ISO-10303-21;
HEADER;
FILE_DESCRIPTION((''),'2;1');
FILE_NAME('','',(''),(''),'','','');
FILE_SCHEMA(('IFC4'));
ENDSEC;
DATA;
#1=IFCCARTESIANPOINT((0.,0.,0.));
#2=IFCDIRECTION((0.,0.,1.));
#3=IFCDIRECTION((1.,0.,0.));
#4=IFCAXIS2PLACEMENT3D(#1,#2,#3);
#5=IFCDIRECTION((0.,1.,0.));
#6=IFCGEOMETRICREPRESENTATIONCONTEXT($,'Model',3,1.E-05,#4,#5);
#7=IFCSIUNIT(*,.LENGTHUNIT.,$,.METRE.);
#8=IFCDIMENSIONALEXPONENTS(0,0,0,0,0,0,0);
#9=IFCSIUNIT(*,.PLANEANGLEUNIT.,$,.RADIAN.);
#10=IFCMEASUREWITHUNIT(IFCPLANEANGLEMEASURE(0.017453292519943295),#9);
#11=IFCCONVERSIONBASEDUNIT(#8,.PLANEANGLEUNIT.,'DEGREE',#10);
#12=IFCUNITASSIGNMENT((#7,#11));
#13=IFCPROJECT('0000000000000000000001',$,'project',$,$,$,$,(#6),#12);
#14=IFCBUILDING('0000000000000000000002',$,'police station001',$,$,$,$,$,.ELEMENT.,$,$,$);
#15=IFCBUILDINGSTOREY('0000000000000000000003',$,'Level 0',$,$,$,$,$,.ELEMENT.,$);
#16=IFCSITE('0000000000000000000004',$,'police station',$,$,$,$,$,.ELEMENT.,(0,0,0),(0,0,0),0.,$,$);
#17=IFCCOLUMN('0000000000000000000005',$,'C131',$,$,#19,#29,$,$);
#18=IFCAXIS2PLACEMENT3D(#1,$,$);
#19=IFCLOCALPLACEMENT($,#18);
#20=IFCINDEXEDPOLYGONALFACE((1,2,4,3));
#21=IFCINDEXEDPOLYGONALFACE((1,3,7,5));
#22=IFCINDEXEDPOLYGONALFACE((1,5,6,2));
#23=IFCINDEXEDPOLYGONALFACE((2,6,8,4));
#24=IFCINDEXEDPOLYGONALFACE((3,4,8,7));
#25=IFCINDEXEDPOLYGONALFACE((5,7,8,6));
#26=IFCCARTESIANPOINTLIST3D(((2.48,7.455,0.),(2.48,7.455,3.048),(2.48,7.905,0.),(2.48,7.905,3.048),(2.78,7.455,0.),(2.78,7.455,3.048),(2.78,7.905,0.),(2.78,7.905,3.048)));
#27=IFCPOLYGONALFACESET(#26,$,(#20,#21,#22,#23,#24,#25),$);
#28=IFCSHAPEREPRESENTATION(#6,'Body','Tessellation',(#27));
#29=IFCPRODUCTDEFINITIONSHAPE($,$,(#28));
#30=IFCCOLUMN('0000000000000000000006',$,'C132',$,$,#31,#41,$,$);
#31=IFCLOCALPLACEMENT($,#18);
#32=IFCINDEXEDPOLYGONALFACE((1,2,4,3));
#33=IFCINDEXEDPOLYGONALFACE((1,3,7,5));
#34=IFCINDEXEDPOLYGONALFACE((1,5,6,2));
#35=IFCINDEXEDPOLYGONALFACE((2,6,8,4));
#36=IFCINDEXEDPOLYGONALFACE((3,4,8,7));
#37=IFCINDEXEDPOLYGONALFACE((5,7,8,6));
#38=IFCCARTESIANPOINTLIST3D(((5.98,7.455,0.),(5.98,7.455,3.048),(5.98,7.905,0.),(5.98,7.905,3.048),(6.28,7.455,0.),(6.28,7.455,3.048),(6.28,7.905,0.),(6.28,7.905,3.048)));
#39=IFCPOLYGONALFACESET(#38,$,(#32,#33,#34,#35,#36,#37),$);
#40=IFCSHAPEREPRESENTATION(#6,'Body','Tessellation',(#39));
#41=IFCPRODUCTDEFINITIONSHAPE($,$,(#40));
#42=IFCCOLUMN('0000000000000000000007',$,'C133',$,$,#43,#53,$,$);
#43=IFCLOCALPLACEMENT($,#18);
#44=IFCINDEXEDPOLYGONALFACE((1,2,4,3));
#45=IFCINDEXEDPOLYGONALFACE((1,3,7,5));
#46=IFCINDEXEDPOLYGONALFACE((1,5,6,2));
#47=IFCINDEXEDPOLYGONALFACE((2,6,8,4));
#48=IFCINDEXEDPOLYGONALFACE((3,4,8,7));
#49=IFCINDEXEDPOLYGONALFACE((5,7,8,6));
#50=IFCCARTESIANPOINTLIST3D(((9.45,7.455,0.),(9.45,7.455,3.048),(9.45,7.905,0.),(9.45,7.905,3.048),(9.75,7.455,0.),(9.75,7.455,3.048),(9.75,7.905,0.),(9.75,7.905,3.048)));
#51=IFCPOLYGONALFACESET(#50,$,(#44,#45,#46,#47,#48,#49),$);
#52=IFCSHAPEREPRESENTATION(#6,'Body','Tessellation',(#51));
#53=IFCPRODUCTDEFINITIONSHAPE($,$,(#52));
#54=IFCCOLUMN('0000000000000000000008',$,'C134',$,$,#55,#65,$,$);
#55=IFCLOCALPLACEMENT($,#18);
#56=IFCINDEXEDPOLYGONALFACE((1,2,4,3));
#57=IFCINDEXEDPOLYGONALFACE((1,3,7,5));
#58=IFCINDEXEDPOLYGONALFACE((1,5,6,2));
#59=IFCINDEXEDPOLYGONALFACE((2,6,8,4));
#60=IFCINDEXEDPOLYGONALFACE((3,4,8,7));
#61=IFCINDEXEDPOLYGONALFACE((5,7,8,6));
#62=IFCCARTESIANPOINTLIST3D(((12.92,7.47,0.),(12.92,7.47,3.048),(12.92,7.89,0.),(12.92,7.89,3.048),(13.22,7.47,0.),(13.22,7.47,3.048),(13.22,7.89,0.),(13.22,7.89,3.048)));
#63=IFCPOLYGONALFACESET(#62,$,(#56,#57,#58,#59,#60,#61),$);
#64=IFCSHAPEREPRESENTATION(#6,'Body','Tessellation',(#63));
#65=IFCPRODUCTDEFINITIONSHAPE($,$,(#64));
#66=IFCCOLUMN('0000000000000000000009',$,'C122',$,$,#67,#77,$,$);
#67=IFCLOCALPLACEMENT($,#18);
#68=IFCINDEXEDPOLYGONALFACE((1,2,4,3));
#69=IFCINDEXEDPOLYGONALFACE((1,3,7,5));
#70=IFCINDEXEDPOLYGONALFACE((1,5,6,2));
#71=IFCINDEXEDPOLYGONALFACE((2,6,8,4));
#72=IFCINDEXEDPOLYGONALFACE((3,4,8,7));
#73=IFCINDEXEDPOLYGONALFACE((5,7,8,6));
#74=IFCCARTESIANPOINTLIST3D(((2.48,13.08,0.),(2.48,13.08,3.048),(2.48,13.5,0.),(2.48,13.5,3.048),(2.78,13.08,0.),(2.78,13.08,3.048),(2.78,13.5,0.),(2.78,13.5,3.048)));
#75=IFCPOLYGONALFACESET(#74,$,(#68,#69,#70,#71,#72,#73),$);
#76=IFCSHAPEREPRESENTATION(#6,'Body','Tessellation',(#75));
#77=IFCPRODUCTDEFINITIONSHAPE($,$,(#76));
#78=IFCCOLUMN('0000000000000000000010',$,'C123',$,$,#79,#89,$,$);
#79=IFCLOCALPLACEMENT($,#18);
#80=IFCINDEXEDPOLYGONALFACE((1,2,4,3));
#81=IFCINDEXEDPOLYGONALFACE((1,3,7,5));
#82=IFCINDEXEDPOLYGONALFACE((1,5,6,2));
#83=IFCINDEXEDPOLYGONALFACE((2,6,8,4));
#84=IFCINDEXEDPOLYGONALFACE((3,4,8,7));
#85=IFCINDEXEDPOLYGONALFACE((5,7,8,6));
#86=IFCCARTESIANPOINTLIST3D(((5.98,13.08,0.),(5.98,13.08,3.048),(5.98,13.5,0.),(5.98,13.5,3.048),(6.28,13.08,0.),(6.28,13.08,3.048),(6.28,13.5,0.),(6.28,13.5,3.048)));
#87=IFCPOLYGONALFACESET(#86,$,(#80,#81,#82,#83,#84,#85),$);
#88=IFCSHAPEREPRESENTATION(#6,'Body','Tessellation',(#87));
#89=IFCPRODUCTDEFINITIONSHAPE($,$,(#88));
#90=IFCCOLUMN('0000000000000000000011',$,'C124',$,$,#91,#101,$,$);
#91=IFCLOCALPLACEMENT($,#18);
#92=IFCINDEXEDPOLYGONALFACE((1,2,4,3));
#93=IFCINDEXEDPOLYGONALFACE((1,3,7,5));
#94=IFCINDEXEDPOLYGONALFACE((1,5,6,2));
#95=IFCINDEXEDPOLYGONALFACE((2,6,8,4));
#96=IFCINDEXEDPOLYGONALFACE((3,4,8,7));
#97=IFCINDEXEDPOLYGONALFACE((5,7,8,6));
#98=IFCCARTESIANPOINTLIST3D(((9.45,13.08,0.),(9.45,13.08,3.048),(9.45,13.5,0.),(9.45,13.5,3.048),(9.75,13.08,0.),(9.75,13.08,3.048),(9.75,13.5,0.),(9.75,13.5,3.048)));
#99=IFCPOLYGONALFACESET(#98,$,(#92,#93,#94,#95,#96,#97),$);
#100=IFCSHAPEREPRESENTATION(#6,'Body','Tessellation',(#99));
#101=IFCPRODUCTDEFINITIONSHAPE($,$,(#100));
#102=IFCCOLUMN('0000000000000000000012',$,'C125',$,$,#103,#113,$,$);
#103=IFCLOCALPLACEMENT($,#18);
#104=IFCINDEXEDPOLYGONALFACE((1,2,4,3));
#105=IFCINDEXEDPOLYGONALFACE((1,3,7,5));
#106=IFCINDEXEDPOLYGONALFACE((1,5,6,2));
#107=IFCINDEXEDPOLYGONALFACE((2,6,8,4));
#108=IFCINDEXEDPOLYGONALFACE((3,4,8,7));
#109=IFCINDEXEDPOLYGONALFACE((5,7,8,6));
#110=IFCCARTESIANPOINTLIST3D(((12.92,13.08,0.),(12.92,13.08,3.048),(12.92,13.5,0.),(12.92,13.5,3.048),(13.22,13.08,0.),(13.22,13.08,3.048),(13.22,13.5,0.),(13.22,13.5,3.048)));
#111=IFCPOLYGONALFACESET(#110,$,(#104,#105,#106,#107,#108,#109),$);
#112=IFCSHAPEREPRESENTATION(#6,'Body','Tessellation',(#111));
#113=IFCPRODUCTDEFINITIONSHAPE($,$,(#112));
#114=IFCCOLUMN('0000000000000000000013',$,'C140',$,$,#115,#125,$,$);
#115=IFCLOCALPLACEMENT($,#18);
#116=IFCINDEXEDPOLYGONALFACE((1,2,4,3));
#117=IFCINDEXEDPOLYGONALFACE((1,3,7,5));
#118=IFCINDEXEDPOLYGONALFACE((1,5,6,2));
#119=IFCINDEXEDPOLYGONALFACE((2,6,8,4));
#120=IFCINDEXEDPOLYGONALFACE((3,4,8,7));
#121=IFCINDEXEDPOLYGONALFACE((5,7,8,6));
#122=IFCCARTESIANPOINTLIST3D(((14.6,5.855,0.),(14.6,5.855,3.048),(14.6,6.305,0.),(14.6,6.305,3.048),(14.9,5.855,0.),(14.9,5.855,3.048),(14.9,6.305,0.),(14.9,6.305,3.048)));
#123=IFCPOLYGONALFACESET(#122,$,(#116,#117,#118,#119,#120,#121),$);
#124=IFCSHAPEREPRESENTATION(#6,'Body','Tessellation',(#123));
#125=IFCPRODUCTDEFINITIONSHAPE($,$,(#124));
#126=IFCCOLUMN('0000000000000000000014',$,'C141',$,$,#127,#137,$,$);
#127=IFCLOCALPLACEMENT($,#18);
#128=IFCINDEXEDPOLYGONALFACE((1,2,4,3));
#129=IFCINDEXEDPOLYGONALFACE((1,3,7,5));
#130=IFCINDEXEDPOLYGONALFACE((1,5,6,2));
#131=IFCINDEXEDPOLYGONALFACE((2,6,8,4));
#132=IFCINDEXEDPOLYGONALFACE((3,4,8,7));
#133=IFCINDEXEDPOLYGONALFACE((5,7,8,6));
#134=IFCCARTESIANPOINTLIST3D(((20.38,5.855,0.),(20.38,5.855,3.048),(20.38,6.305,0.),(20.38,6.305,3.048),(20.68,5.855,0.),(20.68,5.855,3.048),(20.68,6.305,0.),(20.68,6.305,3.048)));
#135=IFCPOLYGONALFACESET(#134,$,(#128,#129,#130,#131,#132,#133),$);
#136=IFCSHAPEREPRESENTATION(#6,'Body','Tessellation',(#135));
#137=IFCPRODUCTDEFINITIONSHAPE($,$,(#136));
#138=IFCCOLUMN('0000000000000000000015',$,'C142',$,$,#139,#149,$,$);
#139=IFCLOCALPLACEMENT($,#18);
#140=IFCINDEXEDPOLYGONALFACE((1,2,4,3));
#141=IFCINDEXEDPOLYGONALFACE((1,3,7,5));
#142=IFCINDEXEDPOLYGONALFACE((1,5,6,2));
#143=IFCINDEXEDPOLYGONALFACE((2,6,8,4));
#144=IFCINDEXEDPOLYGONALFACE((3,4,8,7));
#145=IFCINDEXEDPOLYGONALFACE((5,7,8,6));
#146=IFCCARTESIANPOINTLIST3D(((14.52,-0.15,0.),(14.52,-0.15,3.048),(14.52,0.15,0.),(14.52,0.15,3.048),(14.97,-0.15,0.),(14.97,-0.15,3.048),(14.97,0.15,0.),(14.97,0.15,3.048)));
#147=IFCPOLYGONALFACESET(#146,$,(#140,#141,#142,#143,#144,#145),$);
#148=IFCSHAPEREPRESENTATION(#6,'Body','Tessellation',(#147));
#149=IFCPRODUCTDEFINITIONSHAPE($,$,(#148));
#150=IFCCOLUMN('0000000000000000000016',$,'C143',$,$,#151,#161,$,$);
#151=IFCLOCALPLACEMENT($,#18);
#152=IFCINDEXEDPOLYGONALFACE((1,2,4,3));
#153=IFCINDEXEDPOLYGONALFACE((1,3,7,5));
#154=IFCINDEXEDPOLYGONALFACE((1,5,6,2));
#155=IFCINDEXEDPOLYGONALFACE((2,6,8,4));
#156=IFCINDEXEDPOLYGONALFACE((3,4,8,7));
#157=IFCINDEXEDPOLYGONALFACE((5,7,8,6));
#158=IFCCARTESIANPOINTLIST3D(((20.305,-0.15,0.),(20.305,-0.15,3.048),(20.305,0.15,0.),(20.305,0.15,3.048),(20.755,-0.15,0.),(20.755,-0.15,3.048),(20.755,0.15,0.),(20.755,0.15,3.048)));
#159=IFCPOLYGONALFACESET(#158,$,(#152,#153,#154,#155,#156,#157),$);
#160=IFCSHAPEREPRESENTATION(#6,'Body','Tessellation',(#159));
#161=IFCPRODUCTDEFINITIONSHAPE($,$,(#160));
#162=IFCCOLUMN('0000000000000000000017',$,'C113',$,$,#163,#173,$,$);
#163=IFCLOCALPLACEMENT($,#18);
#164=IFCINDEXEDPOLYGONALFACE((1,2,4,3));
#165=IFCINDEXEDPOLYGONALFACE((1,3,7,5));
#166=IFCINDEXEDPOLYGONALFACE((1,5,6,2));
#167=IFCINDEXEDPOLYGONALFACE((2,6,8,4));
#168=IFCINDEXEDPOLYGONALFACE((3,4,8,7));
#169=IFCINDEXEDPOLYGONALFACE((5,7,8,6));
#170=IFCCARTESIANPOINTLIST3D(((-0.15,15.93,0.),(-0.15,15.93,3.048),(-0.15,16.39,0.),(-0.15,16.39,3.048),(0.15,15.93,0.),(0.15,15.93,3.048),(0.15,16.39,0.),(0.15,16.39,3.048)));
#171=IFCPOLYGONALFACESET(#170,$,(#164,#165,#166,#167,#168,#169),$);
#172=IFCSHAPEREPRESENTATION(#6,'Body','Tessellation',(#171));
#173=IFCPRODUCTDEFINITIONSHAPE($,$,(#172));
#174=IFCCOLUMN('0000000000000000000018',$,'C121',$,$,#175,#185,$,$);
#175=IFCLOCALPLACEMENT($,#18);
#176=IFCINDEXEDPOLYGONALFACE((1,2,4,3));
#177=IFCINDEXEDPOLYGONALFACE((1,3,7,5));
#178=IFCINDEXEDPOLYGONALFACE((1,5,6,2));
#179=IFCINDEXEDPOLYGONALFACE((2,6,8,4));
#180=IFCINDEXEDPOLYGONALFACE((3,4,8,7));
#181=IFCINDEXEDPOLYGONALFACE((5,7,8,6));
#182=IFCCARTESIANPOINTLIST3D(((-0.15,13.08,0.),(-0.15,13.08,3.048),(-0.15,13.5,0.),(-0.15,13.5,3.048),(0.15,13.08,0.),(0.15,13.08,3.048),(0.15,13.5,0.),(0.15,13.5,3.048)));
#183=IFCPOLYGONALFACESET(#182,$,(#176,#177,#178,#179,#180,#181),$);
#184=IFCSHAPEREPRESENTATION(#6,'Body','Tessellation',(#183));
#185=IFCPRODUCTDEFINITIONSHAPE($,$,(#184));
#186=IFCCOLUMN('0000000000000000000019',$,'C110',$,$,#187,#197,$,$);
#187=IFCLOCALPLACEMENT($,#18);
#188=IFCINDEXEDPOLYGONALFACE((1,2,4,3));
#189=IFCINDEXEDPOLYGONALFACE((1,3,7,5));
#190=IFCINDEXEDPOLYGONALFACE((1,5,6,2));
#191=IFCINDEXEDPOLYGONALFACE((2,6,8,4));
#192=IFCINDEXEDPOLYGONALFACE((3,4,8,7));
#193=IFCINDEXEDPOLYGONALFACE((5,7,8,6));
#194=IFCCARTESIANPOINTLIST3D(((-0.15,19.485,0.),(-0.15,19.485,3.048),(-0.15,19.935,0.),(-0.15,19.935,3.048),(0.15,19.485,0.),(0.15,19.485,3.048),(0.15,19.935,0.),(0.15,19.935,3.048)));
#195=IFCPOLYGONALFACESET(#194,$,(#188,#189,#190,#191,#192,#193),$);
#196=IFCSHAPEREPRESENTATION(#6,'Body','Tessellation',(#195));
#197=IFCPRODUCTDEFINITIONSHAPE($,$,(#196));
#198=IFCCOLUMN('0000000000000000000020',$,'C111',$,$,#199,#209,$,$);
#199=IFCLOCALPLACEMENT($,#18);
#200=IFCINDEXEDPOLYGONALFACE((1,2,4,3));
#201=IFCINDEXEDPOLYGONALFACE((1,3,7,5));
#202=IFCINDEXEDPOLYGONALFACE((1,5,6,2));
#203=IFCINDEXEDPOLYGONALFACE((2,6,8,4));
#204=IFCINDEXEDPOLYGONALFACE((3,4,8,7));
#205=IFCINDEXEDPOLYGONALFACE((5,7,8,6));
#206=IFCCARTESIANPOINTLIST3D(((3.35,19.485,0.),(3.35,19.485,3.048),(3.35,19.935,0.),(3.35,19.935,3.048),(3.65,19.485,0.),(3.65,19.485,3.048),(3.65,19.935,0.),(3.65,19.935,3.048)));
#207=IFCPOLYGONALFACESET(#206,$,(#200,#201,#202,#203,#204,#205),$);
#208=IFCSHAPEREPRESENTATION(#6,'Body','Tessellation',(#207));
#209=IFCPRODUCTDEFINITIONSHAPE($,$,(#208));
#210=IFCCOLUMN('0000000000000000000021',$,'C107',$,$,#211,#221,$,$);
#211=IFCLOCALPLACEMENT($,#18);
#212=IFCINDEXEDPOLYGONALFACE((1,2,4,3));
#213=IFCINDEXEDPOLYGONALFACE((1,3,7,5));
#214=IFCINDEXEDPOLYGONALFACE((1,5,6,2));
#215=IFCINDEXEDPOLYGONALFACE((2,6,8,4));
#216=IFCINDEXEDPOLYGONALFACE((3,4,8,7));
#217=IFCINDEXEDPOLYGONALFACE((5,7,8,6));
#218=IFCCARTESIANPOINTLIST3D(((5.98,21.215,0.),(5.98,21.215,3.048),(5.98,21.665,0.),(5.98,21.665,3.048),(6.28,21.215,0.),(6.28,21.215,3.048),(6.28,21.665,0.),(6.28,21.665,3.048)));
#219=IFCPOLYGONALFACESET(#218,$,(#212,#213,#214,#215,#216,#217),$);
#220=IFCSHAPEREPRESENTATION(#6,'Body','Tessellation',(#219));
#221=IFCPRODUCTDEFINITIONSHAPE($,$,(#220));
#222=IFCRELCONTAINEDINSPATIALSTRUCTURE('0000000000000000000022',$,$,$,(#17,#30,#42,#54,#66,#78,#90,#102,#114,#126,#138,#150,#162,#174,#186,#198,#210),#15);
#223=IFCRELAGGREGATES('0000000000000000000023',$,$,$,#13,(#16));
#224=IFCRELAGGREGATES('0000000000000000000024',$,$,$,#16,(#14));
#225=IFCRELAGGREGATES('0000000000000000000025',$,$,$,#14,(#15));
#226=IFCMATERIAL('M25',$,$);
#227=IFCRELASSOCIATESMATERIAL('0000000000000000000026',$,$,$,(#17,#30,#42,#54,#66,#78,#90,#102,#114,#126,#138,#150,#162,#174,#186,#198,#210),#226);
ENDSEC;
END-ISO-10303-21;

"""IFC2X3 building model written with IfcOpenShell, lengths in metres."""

from ifc_helpers import new_model, entity, si_unit, converted_unit, direction, frame, frame_2d, origin_with_axes, place, context, project, spatial, rectangle, extrude, material, element, save


model = new_model("IFC2X3")

# Units and contexts
model_context = context("Model", 3, precision=1e-05, world=origin_with_axes(), true_north=direction((0.0, 1.0, 0.0)))
ifc_project = project(units=[si_unit("LENGTHUNIT", "METRE"), converted_unit("PLANEANGLEUNIT", "DEGREE", entity("IfcPlaneAngleMeasure", 0.017453292519943295), si_unit("PLANEANGLEUNIT", "RADIAN"), dimensions=[0, 0, 0, 0, 0, 0, 0])], contexts=[model_context])

# Site, building, storey
site = spatial("IfcSite", under=ifc_project, Name="police station", CompositionType="ELEMENT", RefLatitude=(0, 0, 0), RefLongitude=(0, 0, 0), RefElevation=0.0)
building = spatial("IfcBuilding", under=site, Name="police station001", CompositionType="ELEMENT")
storey = spatial("IfcBuildingStorey", under=building, Name="Level 0", CompositionType="ELEMENT")

# Columns
ifc_material = material(Name="M25")
placement = place(None, origin_with_axes())
element("IfcColumn", 1, at=placement, inside=storey, material=ifc_material, Name="C131", context=model_context, shape_type="SweptSolid", body=[
    extrude(rectangle(XDim=0.3, YDim=0.45, at=frame_2d((0.0, 0.0), x_axis=(1.0, 0.0, 0.0))), frame((2.63, 7.68, 0.0), z_axis=(0.0, 0.0, 1.0), x_axis=(1.0, 0.0, 0.0)), (0.0, 0.0, 1.0), 3.048),
])
element("IfcColumn", 2, at=placement, inside=storey, material=ifc_material, Name="C132", context=model_context, shape_type="SweptSolid", body=[
    extrude(rectangle(XDim=0.3, YDim=0.45, at=frame_2d((0.0, 0.0), x_axis=(1.0, 0.0, 0.0))), frame((6.13, 7.68, 0.0), z_axis=(0.0, 0.0, 1.0), x_axis=(1.0, 0.0, 0.0)), (0.0, 0.0, 1.0), 3.048),
])
element("IfcColumn", 3, at=placement, inside=storey, material=ifc_material, Name="C133", context=model_context, shape_type="SweptSolid", body=[
    extrude(rectangle(XDim=0.3, YDim=0.45, at=frame_2d((0.0, 0.0), x_axis=(1.0, 0.0, 0.0))), frame((9.6, 7.68, 0.0), z_axis=(0.0, 0.0, 1.0), x_axis=(1.0, 0.0, 0.0)), (0.0, 0.0, 1.0), 3.048),
])
element("IfcColumn", 4, at=placement, inside=storey, material=ifc_material, Name="C134", context=model_context, shape_type="SweptSolid", body=[
    extrude(rectangle(XDim=0.3, YDim=0.42, at=frame_2d((0.0, 0.0), x_axis=(1.0, 0.0, 0.0))), frame((13.07, 7.68, 0.0), z_axis=(0.0, 0.0, 1.0), x_axis=(1.0, 0.0, 0.0)), (0.0, 0.0, 1.0), 3.048),
])
element("IfcColumn", 5, at=placement, inside=storey, material=ifc_material, Name="C122", context=model_context, shape_type="SweptSolid", body=[
    extrude(rectangle(XDim=0.3, YDim=0.42, at=frame_2d((0.0, 0.0), x_axis=(1.0, 0.0, 0.0))), frame((2.63, 13.29, 0.0), z_axis=(0.0, 0.0, 1.0), x_axis=(1.0, 0.0, 0.0)), (0.0, 0.0, 1.0), 3.048),
])
element("IfcColumn", 6, at=placement, inside=storey, material=ifc_material, Name="C123", context=model_context, shape_type="SweptSolid", body=[
    extrude(rectangle(XDim=0.3, YDim=0.42, at=frame_2d((0.0, 0.0), x_axis=(1.0, 0.0, 0.0))), frame((6.13, 13.29, 0.0), z_axis=(0.0, 0.0, 1.0), x_axis=(1.0, 0.0, 0.0)), (0.0, 0.0, 1.0), 3.048),
])
element("IfcColumn", 7, at=placement, inside=storey, material=ifc_material, Name="C124", context=model_context, shape_type="SweptSolid", body=[
    extrude(rectangle(XDim=0.3, YDim=0.42, at=frame_2d((0.0, 0.0), x_axis=(1.0, 0.0, 0.0))), frame((9.6, 13.29, 0.0), z_axis=(0.0, 0.0, 1.0), x_axis=(1.0, 0.0, 0.0)), (0.0, 0.0, 1.0), 3.048),
])
element("IfcColumn", 8, at=placement, inside=storey, material=ifc_material, Name="C125", context=model_context, shape_type="SweptSolid", body=[
    extrude(rectangle(XDim=0.3, YDim=0.42, at=frame_2d((0.0, 0.0), x_axis=(1.0, 0.0, 0.0))), frame((13.07, 13.29, 0.0), z_axis=(0.0, 0.0, 1.0), x_axis=(1.0, 0.0, 0.0)), (0.0, 0.0, 1.0), 3.048),
])
element("IfcColumn", 9, at=placement, inside=storey, material=ifc_material, Name="C140", context=model_context, shape_type="SweptSolid", body=[
    extrude(rectangle(XDim=0.3, YDim=0.45, at=frame_2d((0.0, 0.0), x_axis=(1.0, 0.0, 0.0))), frame((14.75, 6.08, 0.0), z_axis=(0.0, 0.0, 1.0), x_axis=(1.0, 0.0, 0.0)), (0.0, 0.0, 1.0), 3.048),
])
element("IfcColumn", 10, at=placement, inside=storey, material=ifc_material, Name="C141", context=model_context, shape_type="SweptSolid", body=[
    extrude(rectangle(XDim=0.3, YDim=0.45, at=frame_2d((0.0, 0.0), x_axis=(1.0, 0.0, 0.0))), frame((20.53, 6.08, 0.0), z_axis=(0.0, 0.0, 1.0), x_axis=(1.0, 0.0, 0.0)), (0.0, 0.0, 1.0), 3.048),
])
element("IfcColumn", 11, at=placement, inside=storey, material=ifc_material, Name="C142", context=model_context, shape_type="SweptSolid", body=[
    extrude(rectangle(XDim=0.45, YDim=0.3, at=frame_2d((0.0, 0.0), x_axis=(1.0, 0.0, 0.0))), frame((14.745, 0.0, 0.0), z_axis=(0.0, 0.0, 1.0), x_axis=(1.0, 0.0, 0.0)), (0.0, 0.0, 1.0), 3.048),
])
element("IfcColumn", 12, at=placement, inside=storey, material=ifc_material, Name="C143", context=model_context, shape_type="SweptSolid", body=[
    extrude(rectangle(XDim=0.45, YDim=0.3, at=frame_2d((0.0, 0.0), x_axis=(1.0, 0.0, 0.0))), frame((20.53, 0.0, 0.0), z_axis=(0.0, 0.0, 1.0), x_axis=(1.0, 0.0, 0.0)), (0.0, 0.0, 1.0), 3.048),
])
element("IfcColumn", 13, at=placement, inside=storey, material=ifc_material, Name="C113", context=model_context, shape_type="SweptSolid", body=[
    extrude(rectangle(XDim=0.3, YDim=0.46, at=frame_2d((0.0, 0.0), x_axis=(1.0, 0.0, 0.0))), frame((0.0, 16.16, 0.0), z_axis=(0.0, 0.0, 1.0), x_axis=(1.0, 0.0, 0.0)), (0.0, 0.0, 1.0), 3.048),
])
element("IfcColumn", 14, at=placement, inside=storey, material=ifc_material, Name="C121", context=model_context, shape_type="SweptSolid", body=[
    extrude(rectangle(XDim=0.3, YDim=0.42, at=frame_2d((0.0, 0.0), x_axis=(1.0, 0.0, 0.0))), frame((0.0, 13.29, 0.0), z_axis=(0.0, 0.0, 1.0), x_axis=(1.0, 0.0, 0.0)), (0.0, 0.0, 1.0), 3.048),
])
element("IfcColumn", 15, at=placement, inside=storey, material=ifc_material, Name="C110", context=model_context, shape_type="SweptSolid", body=[
    extrude(rectangle(XDim=0.3, YDim=0.45, at=frame_2d((0.0, 0.0), x_axis=(1.0, 0.0, 0.0))), frame((0.0, 19.71, 0.0), z_axis=(0.0, 0.0, 1.0), x_axis=(1.0, 0.0, 0.0)), (0.0, 0.0, 1.0), 3.048),
])
element("IfcColumn", 16, at=placement, inside=storey, material=ifc_material, Name="C111", context=model_context, shape_type="SweptSolid", body=[
    extrude(rectangle(XDim=0.3, YDim=0.45, at=frame_2d((0.0, 0.0), x_axis=(1.0, 0.0, 0.0))), frame((3.5, 19.71, 0.0), z_axis=(0.0, 0.0, 1.0), x_axis=(1.0, 0.0, 0.0)), (0.0, 0.0, 1.0), 3.048),
])
element("IfcColumn", 17, at=placement, inside=storey, material=ifc_material, Name="C107", context=model_context, shape_type="SweptSolid", body=[
    extrude(rectangle(XDim=0.3, YDim=0.45, at=frame_2d((0.0, 0.0), x_axis=(1.0, 0.0, 0.0))), frame((6.13, 21.44, 0.0), z_axis=(0.0, 0.0, 1.0), x_axis=(1.0, 0.0, 0.0)), (0.0, 0.0, 1.0), 3.048),
])

save(model, "model.ifc")
